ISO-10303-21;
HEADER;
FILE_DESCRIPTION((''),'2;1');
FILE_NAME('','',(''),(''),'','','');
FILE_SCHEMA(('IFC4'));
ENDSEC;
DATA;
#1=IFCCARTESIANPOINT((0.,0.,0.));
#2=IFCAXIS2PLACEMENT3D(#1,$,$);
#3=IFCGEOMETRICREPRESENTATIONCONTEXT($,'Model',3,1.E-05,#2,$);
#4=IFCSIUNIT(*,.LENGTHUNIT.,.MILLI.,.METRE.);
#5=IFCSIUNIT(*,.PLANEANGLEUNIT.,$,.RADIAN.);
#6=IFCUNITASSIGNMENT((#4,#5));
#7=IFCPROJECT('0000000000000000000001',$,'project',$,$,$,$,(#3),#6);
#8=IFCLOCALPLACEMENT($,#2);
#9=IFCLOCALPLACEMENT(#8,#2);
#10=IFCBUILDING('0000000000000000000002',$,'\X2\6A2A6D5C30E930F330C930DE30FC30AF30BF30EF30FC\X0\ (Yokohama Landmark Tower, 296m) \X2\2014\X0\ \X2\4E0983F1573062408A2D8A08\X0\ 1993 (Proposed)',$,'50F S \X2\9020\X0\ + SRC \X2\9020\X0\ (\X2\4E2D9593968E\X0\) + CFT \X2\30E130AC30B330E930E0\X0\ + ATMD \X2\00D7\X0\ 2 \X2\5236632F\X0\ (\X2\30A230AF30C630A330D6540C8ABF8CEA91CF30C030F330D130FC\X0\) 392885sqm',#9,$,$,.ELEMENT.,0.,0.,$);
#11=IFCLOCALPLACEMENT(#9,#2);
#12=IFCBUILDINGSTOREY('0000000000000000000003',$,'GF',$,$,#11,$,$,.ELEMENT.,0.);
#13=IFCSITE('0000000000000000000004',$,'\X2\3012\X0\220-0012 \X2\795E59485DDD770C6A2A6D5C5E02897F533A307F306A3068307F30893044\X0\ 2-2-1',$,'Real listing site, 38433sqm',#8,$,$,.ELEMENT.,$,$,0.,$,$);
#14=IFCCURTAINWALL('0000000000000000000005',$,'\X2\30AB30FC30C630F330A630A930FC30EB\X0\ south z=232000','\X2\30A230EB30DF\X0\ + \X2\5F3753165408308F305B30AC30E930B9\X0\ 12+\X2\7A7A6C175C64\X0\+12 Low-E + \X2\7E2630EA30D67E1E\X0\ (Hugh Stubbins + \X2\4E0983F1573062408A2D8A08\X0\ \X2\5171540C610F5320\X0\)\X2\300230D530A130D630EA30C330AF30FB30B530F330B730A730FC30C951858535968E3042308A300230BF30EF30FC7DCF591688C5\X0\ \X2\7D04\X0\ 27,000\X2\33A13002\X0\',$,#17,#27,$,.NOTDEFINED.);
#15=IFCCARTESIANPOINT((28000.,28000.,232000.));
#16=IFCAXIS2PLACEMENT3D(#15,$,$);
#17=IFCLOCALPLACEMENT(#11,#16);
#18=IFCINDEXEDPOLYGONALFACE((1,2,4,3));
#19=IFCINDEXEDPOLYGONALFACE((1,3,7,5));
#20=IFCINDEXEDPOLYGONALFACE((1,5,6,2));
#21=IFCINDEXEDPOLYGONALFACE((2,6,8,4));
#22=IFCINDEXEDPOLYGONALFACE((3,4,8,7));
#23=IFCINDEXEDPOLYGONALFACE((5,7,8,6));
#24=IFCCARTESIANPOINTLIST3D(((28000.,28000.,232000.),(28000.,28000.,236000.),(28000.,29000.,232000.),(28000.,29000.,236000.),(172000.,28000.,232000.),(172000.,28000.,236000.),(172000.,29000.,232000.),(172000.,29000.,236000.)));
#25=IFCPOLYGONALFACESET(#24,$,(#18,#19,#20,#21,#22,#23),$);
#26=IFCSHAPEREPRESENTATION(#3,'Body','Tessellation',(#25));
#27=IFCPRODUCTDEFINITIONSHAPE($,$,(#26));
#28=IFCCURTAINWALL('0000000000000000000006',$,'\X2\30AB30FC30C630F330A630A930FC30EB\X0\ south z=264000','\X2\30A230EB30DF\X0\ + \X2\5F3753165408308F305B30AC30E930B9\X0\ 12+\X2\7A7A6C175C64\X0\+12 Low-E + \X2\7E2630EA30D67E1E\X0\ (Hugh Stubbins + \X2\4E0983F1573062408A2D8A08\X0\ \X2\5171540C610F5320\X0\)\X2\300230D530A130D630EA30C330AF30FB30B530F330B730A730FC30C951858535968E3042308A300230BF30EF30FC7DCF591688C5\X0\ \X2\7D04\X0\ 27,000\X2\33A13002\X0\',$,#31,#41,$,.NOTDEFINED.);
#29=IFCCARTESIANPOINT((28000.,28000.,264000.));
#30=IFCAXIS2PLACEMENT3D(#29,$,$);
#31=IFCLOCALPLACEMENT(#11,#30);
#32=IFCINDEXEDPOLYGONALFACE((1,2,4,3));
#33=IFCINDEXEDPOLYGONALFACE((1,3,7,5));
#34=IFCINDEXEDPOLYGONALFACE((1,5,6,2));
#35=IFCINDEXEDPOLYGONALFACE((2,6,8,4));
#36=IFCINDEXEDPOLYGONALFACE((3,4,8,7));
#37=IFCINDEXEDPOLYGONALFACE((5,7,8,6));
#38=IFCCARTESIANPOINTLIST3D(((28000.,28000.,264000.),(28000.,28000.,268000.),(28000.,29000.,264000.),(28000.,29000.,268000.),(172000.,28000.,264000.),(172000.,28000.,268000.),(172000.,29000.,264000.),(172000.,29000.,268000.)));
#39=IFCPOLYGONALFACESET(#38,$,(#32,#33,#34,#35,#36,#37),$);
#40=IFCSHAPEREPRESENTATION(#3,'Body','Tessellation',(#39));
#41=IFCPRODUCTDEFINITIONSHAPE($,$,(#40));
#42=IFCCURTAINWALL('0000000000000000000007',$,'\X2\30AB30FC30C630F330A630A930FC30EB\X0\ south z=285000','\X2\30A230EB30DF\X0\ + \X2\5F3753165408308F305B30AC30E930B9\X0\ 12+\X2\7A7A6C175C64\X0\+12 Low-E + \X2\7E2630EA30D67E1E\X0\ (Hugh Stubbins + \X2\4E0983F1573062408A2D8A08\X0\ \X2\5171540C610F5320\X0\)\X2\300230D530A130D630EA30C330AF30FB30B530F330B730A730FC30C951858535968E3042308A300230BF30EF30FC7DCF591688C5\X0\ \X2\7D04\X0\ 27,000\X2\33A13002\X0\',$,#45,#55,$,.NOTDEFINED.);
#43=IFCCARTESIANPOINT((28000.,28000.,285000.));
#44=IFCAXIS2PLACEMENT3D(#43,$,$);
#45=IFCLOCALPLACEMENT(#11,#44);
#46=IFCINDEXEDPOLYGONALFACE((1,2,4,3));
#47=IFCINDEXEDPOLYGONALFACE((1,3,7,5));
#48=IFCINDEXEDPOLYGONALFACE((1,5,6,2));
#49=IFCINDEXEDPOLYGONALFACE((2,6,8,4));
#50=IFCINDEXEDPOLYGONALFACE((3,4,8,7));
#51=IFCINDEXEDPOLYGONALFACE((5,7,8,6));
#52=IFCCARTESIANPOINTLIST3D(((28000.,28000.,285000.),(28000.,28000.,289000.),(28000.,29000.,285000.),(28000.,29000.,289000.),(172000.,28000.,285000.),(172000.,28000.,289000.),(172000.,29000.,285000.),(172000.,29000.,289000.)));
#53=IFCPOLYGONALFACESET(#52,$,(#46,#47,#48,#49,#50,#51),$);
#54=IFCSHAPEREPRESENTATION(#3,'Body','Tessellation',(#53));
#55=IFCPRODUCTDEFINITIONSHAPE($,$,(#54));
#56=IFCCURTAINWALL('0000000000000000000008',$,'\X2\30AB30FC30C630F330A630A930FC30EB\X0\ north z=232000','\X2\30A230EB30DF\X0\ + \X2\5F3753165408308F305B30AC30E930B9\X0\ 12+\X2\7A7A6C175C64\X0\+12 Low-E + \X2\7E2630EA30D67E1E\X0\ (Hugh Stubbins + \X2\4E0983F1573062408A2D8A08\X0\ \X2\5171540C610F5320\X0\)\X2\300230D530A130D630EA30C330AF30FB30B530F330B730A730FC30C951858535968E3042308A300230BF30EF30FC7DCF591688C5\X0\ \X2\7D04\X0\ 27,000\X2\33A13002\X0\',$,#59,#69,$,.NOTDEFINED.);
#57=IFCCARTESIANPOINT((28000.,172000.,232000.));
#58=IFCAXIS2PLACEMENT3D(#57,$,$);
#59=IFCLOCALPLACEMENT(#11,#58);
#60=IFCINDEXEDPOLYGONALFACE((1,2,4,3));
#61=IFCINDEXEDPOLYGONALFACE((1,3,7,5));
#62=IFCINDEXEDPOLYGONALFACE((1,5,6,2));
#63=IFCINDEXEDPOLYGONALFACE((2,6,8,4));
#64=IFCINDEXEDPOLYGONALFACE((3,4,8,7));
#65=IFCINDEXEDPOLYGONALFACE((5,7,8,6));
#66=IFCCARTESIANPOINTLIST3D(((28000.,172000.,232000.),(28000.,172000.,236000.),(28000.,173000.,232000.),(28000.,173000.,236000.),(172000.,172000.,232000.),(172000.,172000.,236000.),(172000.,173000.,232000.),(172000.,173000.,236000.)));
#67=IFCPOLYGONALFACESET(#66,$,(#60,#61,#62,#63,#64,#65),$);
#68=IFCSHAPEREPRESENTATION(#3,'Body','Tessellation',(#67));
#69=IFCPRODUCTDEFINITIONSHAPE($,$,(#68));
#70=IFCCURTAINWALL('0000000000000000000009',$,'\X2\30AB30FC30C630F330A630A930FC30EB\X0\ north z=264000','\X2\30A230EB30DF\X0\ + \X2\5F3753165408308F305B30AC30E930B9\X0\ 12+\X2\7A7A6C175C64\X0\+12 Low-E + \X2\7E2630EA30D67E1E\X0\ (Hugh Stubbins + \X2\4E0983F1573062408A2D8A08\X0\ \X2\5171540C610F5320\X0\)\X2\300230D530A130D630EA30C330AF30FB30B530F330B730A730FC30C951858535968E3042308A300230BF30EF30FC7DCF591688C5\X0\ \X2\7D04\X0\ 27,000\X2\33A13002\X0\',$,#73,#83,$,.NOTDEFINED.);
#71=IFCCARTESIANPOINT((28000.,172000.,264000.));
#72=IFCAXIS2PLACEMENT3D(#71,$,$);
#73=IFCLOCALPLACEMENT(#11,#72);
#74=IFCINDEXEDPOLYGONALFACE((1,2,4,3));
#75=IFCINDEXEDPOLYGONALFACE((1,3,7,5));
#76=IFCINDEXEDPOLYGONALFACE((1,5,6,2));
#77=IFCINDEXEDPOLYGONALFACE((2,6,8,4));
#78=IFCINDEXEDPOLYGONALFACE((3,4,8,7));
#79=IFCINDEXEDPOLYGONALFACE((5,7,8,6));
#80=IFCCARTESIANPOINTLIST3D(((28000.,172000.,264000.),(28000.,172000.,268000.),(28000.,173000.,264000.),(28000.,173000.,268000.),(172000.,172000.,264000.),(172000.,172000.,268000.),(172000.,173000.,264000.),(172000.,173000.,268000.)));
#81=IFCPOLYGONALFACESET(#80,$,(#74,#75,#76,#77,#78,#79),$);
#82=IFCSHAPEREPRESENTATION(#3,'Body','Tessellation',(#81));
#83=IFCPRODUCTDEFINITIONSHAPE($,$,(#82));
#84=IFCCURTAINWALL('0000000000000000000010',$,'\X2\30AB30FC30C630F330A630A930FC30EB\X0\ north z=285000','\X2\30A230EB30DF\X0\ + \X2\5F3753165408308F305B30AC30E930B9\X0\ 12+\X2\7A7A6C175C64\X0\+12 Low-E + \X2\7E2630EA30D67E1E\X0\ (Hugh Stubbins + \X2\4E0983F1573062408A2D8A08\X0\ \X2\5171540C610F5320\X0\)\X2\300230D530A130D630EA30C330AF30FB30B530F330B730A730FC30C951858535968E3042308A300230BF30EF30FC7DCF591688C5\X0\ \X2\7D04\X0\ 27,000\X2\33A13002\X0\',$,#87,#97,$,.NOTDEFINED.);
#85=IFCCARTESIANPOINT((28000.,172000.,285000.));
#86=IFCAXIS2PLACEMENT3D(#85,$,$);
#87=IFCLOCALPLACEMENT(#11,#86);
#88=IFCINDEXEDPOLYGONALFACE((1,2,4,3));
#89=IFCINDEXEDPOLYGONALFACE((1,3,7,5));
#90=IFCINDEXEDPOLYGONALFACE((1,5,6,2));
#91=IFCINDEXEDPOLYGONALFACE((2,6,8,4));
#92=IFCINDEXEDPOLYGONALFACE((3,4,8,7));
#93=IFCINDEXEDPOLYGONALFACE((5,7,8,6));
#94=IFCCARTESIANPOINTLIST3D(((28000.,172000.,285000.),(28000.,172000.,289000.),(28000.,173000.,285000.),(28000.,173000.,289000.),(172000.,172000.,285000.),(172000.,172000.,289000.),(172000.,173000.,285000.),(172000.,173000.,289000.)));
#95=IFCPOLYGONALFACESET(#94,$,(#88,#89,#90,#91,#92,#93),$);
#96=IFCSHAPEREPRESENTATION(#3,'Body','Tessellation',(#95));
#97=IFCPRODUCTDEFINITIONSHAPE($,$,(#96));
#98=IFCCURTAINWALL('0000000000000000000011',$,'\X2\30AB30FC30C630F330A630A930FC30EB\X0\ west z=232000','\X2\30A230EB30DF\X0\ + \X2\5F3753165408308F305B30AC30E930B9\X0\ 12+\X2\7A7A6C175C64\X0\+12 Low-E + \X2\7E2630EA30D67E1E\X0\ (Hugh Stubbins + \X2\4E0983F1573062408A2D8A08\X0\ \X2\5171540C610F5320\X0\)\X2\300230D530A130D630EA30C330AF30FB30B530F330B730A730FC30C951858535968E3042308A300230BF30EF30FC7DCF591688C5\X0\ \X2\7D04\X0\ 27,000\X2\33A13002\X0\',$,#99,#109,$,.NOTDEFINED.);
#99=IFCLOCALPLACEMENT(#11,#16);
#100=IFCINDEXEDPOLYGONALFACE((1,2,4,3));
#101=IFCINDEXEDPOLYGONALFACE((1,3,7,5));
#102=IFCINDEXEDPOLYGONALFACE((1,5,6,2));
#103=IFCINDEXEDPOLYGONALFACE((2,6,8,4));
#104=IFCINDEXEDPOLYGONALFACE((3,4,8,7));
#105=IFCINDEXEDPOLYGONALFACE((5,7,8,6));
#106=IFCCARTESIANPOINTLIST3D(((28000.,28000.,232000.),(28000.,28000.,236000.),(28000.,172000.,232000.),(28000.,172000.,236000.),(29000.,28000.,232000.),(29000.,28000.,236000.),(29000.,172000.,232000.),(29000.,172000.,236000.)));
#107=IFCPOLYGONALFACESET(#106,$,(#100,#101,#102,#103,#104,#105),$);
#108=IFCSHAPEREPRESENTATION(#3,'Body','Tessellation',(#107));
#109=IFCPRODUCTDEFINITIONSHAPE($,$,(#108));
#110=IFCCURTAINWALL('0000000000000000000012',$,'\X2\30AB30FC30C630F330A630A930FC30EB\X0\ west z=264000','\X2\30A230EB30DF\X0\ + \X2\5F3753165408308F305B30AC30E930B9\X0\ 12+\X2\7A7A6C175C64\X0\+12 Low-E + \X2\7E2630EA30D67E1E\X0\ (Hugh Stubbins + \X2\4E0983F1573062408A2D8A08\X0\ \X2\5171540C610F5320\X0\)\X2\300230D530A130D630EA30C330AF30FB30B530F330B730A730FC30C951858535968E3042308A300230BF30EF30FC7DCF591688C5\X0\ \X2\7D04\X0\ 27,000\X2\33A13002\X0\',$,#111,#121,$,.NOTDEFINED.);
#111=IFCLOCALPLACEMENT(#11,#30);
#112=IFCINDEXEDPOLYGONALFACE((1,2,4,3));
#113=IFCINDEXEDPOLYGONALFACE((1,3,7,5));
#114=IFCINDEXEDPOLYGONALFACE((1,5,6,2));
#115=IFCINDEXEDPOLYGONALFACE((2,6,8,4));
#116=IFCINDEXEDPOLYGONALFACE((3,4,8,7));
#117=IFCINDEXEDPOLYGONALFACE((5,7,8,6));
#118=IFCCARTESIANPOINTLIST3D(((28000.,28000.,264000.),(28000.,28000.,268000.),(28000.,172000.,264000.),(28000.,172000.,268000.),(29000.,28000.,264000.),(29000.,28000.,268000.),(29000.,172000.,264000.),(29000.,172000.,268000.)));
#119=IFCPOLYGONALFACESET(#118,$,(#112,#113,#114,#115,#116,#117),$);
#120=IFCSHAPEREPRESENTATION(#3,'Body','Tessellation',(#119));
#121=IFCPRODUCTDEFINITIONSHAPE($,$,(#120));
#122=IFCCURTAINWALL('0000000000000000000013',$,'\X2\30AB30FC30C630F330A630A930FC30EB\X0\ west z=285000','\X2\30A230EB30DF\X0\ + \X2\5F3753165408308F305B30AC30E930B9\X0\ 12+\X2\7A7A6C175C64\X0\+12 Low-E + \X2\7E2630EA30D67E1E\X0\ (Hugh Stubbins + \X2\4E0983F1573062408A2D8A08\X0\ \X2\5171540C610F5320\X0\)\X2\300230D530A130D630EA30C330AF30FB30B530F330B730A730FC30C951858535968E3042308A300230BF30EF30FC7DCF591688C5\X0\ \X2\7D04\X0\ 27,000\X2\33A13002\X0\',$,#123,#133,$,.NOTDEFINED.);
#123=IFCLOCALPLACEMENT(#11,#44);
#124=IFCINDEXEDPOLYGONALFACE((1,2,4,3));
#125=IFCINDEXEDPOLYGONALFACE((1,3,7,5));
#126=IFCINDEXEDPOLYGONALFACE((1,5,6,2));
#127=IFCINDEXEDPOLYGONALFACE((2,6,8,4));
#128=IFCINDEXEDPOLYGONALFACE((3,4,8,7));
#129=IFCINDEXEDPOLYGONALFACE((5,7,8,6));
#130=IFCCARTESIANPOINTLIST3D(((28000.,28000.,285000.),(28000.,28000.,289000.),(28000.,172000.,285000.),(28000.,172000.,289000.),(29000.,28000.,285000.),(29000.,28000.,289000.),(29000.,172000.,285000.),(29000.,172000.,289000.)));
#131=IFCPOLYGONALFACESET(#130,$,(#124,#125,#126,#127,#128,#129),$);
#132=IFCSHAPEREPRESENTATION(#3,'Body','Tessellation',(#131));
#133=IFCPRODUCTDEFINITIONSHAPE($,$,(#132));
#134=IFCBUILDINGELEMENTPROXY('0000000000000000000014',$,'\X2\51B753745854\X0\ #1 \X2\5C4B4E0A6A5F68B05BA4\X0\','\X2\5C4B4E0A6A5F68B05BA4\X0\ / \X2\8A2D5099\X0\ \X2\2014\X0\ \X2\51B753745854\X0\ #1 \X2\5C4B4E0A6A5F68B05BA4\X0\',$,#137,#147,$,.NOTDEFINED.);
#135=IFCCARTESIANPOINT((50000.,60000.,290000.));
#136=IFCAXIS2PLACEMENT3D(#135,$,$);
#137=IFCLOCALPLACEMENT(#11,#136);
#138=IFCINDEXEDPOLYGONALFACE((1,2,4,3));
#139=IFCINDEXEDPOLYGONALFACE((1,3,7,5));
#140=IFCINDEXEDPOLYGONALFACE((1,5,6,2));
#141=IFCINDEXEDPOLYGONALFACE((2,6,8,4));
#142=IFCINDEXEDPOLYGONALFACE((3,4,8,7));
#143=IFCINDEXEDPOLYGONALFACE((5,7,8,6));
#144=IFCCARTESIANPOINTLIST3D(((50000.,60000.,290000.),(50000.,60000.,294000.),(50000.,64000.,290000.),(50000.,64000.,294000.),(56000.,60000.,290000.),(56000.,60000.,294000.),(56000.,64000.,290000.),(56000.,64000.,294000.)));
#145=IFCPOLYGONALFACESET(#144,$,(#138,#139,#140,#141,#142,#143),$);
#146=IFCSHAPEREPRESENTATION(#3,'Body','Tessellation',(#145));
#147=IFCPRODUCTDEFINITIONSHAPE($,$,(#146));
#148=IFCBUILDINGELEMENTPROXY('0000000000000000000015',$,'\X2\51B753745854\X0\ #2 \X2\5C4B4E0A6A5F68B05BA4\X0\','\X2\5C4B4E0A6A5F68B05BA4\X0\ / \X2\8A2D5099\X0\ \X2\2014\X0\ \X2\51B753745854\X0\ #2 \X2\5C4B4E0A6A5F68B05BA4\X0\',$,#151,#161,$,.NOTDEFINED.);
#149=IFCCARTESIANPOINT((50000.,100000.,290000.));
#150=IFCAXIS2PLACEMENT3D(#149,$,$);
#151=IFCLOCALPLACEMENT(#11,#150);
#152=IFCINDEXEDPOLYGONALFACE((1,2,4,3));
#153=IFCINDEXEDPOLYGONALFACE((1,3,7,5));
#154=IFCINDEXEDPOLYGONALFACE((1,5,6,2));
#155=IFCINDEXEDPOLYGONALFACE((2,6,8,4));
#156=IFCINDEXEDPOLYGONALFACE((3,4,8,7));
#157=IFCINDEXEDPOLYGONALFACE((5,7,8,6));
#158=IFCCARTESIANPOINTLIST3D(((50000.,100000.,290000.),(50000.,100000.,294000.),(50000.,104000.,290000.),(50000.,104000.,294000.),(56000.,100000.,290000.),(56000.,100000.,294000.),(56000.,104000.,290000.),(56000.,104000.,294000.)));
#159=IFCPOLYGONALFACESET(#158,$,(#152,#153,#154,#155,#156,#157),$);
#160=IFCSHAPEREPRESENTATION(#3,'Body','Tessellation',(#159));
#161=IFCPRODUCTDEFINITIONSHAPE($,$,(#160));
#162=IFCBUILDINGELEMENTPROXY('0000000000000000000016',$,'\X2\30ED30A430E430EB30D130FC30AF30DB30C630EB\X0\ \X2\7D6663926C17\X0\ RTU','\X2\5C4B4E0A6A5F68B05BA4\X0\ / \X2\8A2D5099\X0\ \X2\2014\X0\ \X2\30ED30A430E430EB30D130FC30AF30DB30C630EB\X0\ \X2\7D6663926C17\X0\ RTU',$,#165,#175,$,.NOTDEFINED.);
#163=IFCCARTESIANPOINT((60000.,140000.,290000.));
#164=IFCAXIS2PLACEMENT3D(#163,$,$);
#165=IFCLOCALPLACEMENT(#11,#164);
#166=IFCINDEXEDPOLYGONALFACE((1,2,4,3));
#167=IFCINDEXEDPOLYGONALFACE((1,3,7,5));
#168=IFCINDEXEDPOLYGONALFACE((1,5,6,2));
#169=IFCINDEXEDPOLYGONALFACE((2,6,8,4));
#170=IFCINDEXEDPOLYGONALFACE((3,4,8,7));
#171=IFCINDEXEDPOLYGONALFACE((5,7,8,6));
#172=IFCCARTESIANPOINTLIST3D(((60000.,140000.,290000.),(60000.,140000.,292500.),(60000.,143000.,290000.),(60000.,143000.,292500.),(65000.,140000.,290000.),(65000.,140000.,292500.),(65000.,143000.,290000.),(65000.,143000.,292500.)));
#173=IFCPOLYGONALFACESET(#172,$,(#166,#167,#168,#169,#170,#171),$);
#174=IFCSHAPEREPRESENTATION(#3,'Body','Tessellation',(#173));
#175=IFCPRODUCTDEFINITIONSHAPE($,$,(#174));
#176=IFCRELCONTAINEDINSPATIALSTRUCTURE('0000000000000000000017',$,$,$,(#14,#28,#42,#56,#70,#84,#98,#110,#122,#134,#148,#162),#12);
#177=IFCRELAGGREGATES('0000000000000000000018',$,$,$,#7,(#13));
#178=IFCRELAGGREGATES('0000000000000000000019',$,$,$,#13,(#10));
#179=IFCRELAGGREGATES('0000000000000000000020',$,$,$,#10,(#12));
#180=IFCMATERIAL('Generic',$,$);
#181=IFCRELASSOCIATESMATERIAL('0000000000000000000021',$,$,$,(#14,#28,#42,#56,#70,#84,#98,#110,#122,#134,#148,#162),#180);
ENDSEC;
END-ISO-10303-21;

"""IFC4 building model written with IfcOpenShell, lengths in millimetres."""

from ifc_helpers import new_model, si_unit, frame, frame_2d, origin, place, context, project, spatial, rectangle, extrude, material, element, save


model = new_model("IFC4")

# Units and contexts
model_context = context("Model", 3, precision=1e-05, world=origin())
ifc_project = project(units=[si_unit("LENGTHUNIT", "METRE", prefix="MILLI"), si_unit("PLANEANGLEUNIT", "RADIAN")], contexts=[model_context])

# Site, building, storey
site_placement = place(None, origin())
site = spatial("IfcSite", under=ifc_project, at=site_placement, Name="〒220-0012 神奈川県横浜市西区みなとみらい 2-2-1", ObjectType="Real listing site, 38433sqm", CompositionType="ELEMENT", RefElevation=0.0)
building_placement = place(site_placement, origin())
building = spatial("IfcBuilding", under=site, at=building_placement, Name="横浜ランドマークタワー (Yokohama Landmark Tower, 296m) — 三菱地所設計 1993 (Proposed)", ObjectType="50F S 造 + SRC 造 (中間階) + CFT メガコラム + ATMD × 2 制振 (アクティブ同調質量ダンパー) 392885sqm", CompositionType="ELEMENT", ElevationOfRefHeight=0.0, ElevationOfTerrain=0.0)
storey_placement = place(building_placement, origin())
storey = spatial("IfcBuildingStorey", under=building, at=storey_placement, Name="GF", CompositionType="ELEMENT", Elevation=0.0)

# Shared definitions
ifc_material_1 = material(Name="Generic")

# Curtain walls
curtain_wall_1_placement = place(storey_placement, frame((28000.0, 28000.0, 232000.0)))
element("IfcCurtainWall", 1, at=curtain_wall_1_placement, inside=storey, material=ifc_material_1, Name="カーテンウォール south z=232000", Description="アルミ + 強化合わせガラス 12+空気層+12 Low-E + 縦リブ縞 (Hugh Stubbins + 三菱地所設計 共同意匠)。ファブリック・サンシェード内蔵階あり。タワー総外装 約 27,000㎡。", PredefinedType="NOTDEFINED", context=model_context, shape_type="SweptSolid", body=[
    extrude(rectangle(XDim=144000.0, YDim=1000.0, at=frame_2d((72000.0, 500.0))), frame((28000.0, 28000.0, 232000.0)), (0.0, 0.0, 1.0), 4000.0),
])
curtain_wall_2_placement = place(storey_placement, frame((28000.0, 28000.0, 264000.0)))
element("IfcCurtainWall", 2, at=curtain_wall_2_placement, inside=storey, material=ifc_material_1, Name="カーテンウォール south z=264000", Description="アルミ + 強化合わせガラス 12+空気層+12 Low-E + 縦リブ縞 (Hugh Stubbins + 三菱地所設計 共同意匠)。ファブリック・サンシェード内蔵階あり。タワー総外装 約 27,000㎡。", PredefinedType="NOTDEFINED", context=model_context, shape_type="SweptSolid", body=[
    extrude(rectangle(XDim=144000.0, YDim=1000.0, at=frame_2d((72000.0, 500.0))), frame((28000.0, 28000.0, 264000.0)), (0.0, 0.0, 1.0), 4000.0),
])
curtain_wall_3_placement = place(storey_placement, frame((28000.0, 28000.0, 285000.0)))
element("IfcCurtainWall", 3, at=curtain_wall_3_placement, inside=storey, material=ifc_material_1, Name="カーテンウォール south z=285000", Description="アルミ + 強化合わせガラス 12+空気層+12 Low-E + 縦リブ縞 (Hugh Stubbins + 三菱地所設計 共同意匠)。ファブリック・サンシェード内蔵階あり。タワー総外装 約 27,000㎡。", PredefinedType="NOTDEFINED", context=model_context, shape_type="SweptSolid", body=[
    extrude(rectangle(XDim=144000.0, YDim=1000.0, at=frame_2d((72000.0, 500.0))), frame((28000.0, 28000.0, 285000.0)), (0.0, 0.0, 1.0), 4000.0),
])
curtain_wall_4_placement = place(storey_placement, frame((28000.0, 172000.0, 232000.0)))
element("IfcCurtainWall", 4, at=curtain_wall_4_placement, inside=storey, material=ifc_material_1, Name="カーテンウォール north z=232000", Description="アルミ + 強化合わせガラス 12+空気層+12 Low-E + 縦リブ縞 (Hugh Stubbins + 三菱地所設計 共同意匠)。ファブリック・サンシェード内蔵階あり。タワー総外装 約 27,000㎡。", PredefinedType="NOTDEFINED", context=model_context, shape_type="SweptSolid", body=[
    extrude(rectangle(XDim=144000.0, YDim=1000.0, at=frame_2d((72000.0, 500.0))), frame((28000.0, 172000.0, 232000.0)), (0.0, 0.0, 1.0), 4000.0),
])
curtain_wall_5_placement = place(storey_placement, frame((28000.0, 172000.0, 264000.0)))
element("IfcCurtainWall", 5, at=curtain_wall_5_placement, inside=storey, material=ifc_material_1, Name="カーテンウォール north z=264000", Description="アルミ + 強化合わせガラス 12+空気層+12 Low-E + 縦リブ縞 (Hugh Stubbins + 三菱地所設計 共同意匠)。ファブリック・サンシェード内蔵階あり。タワー総外装 約 27,000㎡。", PredefinedType="NOTDEFINED", context=model_context, shape_type="SweptSolid", body=[
    extrude(rectangle(XDim=144000.0, YDim=1000.0, at=frame_2d((72000.0, 500.0))), frame((28000.0, 172000.0, 264000.0)), (0.0, 0.0, 1.0), 4000.0),
])
curtain_wall_6_placement = place(storey_placement, frame((28000.0, 172000.0, 285000.0)))
element("IfcCurtainWall", 6, at=curtain_wall_6_placement, inside=storey, material=ifc_material_1, Name="カーテンウォール north z=285000", Description="アルミ + 強化合わせガラス 12+空気層+12 Low-E + 縦リブ縞 (Hugh Stubbins + 三菱地所設計 共同意匠)。ファブリック・サンシェード内蔵階あり。タワー総外装 約 27,000㎡。", PredefinedType="NOTDEFINED", context=model_context, shape_type="SweptSolid", body=[
    extrude(rectangle(XDim=144000.0, YDim=1000.0, at=frame_2d((72000.0, 500.0))), frame((28000.0, 172000.0, 285000.0)), (0.0, 0.0, 1.0), 4000.0),
])
curtain_wall_7_placement = place(storey_placement, frame((28000.0, 28000.0, 232000.0)))
element("IfcCurtainWall", 7, at=curtain_wall_7_placement, inside=storey, material=ifc_material_1, Name="カーテンウォール west z=232000", Description="アルミ + 強化合わせガラス 12+空気層+12 Low-E + 縦リブ縞 (Hugh Stubbins + 三菱地所設計 共同意匠)。ファブリック・サンシェード内蔵階あり。タワー総外装 約 27,000㎡。", PredefinedType="NOTDEFINED", context=model_context, shape_type="SweptSolid", body=[
    extrude(rectangle(XDim=1000.0, YDim=144000.0, at=frame_2d((500.0, 72000.0))), frame((28000.0, 28000.0, 232000.0)), (0.0, 0.0, 1.0), 4000.0),
])
curtain_wall_8_placement = place(storey_placement, frame((28000.0, 28000.0, 264000.0)))
element("IfcCurtainWall", 8, at=curtain_wall_8_placement, inside=storey, material=ifc_material_1, Name="カーテンウォール west z=264000", Description="アルミ + 強化合わせガラス 12+空気層+12 Low-E + 縦リブ縞 (Hugh Stubbins + 三菱地所設計 共同意匠)。ファブリック・サンシェード内蔵階あり。タワー総外装 約 27,000㎡。", PredefinedType="NOTDEFINED", context=model_context, shape_type="SweptSolid", body=[
    extrude(rectangle(XDim=1000.0, YDim=144000.0, at=frame_2d((500.0, 72000.0))), frame((28000.0, 28000.0, 264000.0)), (0.0, 0.0, 1.0), 4000.0),
])
curtain_wall_9_placement = place(storey_placement, frame((28000.0, 28000.0, 285000.0)))
element("IfcCurtainWall", 9, at=curtain_wall_9_placement, inside=storey, material=ifc_material_1, Name="カーテンウォール west z=285000", Description="アルミ + 強化合わせガラス 12+空気層+12 Low-E + 縦リブ縞 (Hugh Stubbins + 三菱地所設計 共同意匠)。ファブリック・サンシェード内蔵階あり。タワー総外装 約 27,000㎡。", PredefinedType="NOTDEFINED", context=model_context, shape_type="SweptSolid", body=[
    extrude(rectangle(XDim=1000.0, YDim=144000.0, at=frame_2d((500.0, 72000.0))), frame((28000.0, 28000.0, 285000.0)), (0.0, 0.0, 1.0), 4000.0),
])

# Building element proxies
proxy_1_placement = place(storey_placement, frame((50000.0, 60000.0, 290000.0)))
element("IfcBuildingElementProxy", 10, at=proxy_1_placement, inside=storey, material=ifc_material_1, Name="冷却塔 #1 屋上機械室", Description="屋上機械室 / 設備 — 冷却塔 #1 屋上機械室", PredefinedType="NOTDEFINED", context=model_context, shape_type="SweptSolid", body=[
    extrude(rectangle(XDim=6000.0, YDim=4000.0, at=frame_2d((3000.0, 2000.0))), frame((50000.0, 60000.0, 290000.0)), (0.0, 0.0, 1.0), 4000.0),
])
proxy_2_placement = place(storey_placement, frame((50000.0, 100000.0, 290000.0)))
element("IfcBuildingElementProxy", 11, at=proxy_2_placement, inside=storey, material=ifc_material_1, Name="冷却塔 #2 屋上機械室", Description="屋上機械室 / 設備 — 冷却塔 #2 屋上機械室", PredefinedType="NOTDEFINED", context=model_context, shape_type="SweptSolid", body=[
    extrude(rectangle(XDim=6000.0, YDim=4000.0, at=frame_2d((3000.0, 2000.0))), frame((50000.0, 100000.0, 290000.0)), (0.0, 0.0, 1.0), 4000.0),
])
proxy_3_placement = place(storey_placement, frame((60000.0, 140000.0, 290000.0)))
element("IfcBuildingElementProxy", 12, at=proxy_3_placement, inside=storey, material=ifc_material_1, Name="ロイヤルパークホテル 給排気 RTU", Description="屋上機械室 / 設備 — ロイヤルパークホテル 給排気 RTU", PredefinedType="NOTDEFINED", context=model_context, shape_type="SweptSolid", body=[
    extrude(rectangle(XDim=5000.0, YDim=3000.0, at=frame_2d((2500.0, 1500.0))), frame((60000.0, 140000.0, 290000.0)), (0.0, 0.0, 1.0), 2500.0),
])

save(model, "model.ifc")
